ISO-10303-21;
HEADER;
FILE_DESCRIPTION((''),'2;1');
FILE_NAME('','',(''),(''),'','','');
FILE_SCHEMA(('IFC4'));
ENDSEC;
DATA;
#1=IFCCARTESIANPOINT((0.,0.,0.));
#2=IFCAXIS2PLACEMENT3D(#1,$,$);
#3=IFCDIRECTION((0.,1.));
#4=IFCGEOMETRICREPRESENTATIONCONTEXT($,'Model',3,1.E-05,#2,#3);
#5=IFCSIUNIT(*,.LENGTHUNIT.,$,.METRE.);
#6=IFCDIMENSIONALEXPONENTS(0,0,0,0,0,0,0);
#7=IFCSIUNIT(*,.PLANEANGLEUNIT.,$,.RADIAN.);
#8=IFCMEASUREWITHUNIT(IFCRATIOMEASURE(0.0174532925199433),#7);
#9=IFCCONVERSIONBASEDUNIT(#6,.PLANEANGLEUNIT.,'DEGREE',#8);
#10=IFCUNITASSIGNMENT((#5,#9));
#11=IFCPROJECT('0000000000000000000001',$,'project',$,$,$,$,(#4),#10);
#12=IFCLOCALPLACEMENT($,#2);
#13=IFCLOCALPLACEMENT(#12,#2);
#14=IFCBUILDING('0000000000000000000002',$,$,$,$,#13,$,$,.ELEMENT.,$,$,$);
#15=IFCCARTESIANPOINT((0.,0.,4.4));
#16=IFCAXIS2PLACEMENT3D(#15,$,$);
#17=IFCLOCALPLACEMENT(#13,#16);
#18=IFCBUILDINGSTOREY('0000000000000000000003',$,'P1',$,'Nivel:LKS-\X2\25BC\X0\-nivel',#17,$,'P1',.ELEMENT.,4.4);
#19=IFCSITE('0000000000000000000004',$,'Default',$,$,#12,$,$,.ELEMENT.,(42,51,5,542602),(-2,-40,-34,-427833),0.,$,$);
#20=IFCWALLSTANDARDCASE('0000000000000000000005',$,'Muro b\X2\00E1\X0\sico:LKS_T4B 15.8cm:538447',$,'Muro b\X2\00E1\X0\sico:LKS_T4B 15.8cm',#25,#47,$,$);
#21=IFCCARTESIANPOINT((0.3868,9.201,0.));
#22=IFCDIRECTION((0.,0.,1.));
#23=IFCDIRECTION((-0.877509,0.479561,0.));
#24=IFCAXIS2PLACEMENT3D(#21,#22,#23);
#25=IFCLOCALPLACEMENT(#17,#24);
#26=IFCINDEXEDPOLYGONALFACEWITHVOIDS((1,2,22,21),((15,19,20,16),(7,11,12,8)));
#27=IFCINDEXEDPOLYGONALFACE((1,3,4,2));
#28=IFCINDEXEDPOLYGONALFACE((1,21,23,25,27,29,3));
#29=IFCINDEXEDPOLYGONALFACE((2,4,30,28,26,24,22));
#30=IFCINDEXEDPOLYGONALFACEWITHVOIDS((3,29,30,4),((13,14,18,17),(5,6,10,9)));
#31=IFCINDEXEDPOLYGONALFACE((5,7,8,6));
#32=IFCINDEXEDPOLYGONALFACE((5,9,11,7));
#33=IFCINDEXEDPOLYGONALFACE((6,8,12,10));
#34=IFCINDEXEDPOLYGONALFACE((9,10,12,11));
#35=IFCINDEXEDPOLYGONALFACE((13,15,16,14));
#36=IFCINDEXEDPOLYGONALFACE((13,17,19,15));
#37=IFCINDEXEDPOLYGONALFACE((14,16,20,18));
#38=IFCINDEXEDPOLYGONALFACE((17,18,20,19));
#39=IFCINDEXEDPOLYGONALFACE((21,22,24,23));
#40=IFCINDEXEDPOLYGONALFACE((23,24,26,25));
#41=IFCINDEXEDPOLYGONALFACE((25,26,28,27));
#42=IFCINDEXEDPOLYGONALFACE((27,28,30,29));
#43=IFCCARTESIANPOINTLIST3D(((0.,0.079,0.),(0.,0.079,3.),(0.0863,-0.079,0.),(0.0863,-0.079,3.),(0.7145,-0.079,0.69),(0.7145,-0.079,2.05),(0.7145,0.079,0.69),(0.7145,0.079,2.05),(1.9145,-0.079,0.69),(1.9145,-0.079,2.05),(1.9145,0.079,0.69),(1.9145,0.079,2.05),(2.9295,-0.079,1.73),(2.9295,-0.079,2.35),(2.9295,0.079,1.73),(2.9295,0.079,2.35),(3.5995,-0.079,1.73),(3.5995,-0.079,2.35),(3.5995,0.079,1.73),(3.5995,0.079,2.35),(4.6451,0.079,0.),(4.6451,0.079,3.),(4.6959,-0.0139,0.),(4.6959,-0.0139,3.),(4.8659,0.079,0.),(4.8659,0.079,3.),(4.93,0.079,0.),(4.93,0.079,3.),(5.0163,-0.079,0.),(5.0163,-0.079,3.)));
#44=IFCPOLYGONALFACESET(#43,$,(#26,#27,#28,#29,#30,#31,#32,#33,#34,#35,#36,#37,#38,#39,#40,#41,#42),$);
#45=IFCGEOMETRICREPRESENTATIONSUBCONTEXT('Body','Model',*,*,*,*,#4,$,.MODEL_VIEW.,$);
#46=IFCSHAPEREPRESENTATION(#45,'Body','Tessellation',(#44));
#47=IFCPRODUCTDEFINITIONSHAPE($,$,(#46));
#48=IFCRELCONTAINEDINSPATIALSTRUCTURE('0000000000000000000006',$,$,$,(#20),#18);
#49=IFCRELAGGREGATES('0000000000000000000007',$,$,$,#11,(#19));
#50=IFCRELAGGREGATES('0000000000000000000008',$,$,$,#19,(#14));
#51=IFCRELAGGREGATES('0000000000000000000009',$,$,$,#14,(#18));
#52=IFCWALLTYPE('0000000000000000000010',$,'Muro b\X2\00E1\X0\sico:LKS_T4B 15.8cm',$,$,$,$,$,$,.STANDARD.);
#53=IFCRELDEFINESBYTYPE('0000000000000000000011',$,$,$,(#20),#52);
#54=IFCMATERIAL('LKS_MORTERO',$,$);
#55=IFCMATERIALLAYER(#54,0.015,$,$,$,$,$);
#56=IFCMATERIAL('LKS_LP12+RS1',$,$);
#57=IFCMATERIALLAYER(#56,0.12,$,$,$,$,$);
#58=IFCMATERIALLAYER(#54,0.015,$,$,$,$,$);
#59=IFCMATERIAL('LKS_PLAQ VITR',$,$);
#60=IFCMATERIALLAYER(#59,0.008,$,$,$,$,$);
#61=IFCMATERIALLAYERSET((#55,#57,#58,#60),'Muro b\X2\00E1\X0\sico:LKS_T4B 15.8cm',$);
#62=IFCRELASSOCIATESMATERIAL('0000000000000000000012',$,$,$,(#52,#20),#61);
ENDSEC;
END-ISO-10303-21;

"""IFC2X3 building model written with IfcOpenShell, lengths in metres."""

from ifc_helpers import new_model, entity, si_unit, converted_unit, direction, frame, frame_2d, origin, place, context, subcontext, project, spatial, polyline, rectangle, outline, extrude, clip, bounded_halfspace, material, layer, layer_set, layer_usage, type_object, element, save


model = new_model("IFC2X3")

# Units and contexts
model_context = context("Model", 3, precision=1e-05, world=origin(), true_north=direction((0.0, 1.0)))
body_context = subcontext(model_context, "Body", "Model", "MODEL_VIEW")
ifc_project = project(units=[si_unit("LENGTHUNIT", "METRE"), converted_unit("PLANEANGLEUNIT", "DEGREE", entity("IfcRatioMeasure", 0.0174532925199433), si_unit("PLANEANGLEUNIT", "RADIAN"), dimensions=[0, 0, 0, 0, 0, 0, 0])], contexts=[model_context])

# Site, building, storey
site_placement = place(None, origin())
site = spatial("IfcSite", under=ifc_project, at=site_placement, Name="Default", CompositionType="ELEMENT", RefLatitude=(42, 51, 5, 542602), RefLongitude=(-2, -40, -34, -427833), RefElevation=0.0)
building_placement = place(site_placement, origin())
building = spatial("IfcBuilding", under=site, at=building_placement, CompositionType="ELEMENT")
storey_placement = place(building_placement, frame((0.0, 0.0, 4.4)))
storey = spatial("IfcBuildingStorey", under=building, at=storey_placement, Name="P1", ObjectType="Nivel:LKS-▼-nivel", LongName="P1", CompositionType="ELEMENT", Elevation=4.4)

# Wall, openings
ifc_material_1 = material(Name="LKS_MORTERO")
ifc_layer_1 = layer(ifc_material_1, 0.015)
ifc_material_2 = material(Name="LKS_LP12+RS1")
ifc_layer_2 = layer(ifc_material_2, 0.12)
ifc_layer_3 = layer(ifc_material_1, 0.015)
ifc_material_3 = material(Name="LKS_PLAQ VITR")
ifc_layer_4 = layer(ifc_material_3, 0.008)
ifc_layer_set_1 = layer_set([ifc_layer_1, ifc_layer_2, ifc_layer_3, ifc_layer_4], Name="Muro básico:LKS_T4B 15.8cm")
ifc_layer_usage_1 = layer_usage(ifc_layer_set_1, "AXIS2", "POSITIVE", -0.079)
wall_type_1 = type_object("IfcWallType", Name="Muro básico:LKS_T4B 15.8cm", PredefinedType="STANDARD", material=ifc_layer_set_1)
wall_1_placement = place(storey_placement, frame((0.3868, 9.201, 0.0), z_axis=(0.0, 0.0, 1.0), x_axis=(-0.877509, 0.479561, 0.0)))
wall_1 = element("IfcWallStandardCase", 1, at=wall_1_placement, inside=storey, type_object=wall_type_1, material=ifc_layer_usage_1, Name="Muro básico:LKS_T4B 15.8cm:538447", ObjectType="Muro básico:LKS_T4B 15.8cm", context=body_context, shape_type="Clipping", body=[
    clip(clip(extrude(outline(polyline([(5.0163, -0.079), (4.9306, 0.078), (4.93, 0.079), (4.8659, 0.079), (4.6959, -0.0139), (4.6457, 0.078), (4.6451, 0.079), (3.1672, 0.079), (3.0672, 0.079), (0.2712, 0.079), (0.0, 0.079), (0.0006, 0.078), (0.0863, -0.079), (5.0163, -0.079)])), origin(), (0.0, 0.0, 1.0), 3.0), bounded_halfspace(frame((4.6959, -0.0139, 3.0), z_axis=(-0.877509, -0.479561, 0.0), x_axis=(0.0, 0.0, -1.0)), True, frame((4.6959, -0.0139, 3.0), z_axis=(-0.877509, -0.479561, 0.0), x_axis=(0.0, 0.0, -1.0)), polyline([(0.0, 0.0), (0.0, -0.1059), (3.0, -0.1059), (3.0, -0.1047), (3.0, 0.0), (0.33, 0.0), (0.0, 0.0)]))), bounded_halfspace(frame((4.6959, -0.0139, 0.0), z_axis=(0.479561, -0.877509, 0.0), x_axis=(0.0, 0.0, -1.0)), True, frame((4.6959, -0.0139, 0.0), z_axis=(0.479561, -0.877509, 0.0), x_axis=(0.0, 0.0, -1.0)), polyline([(0.0, 0.0), (0.0, 0.1938), (-3.0, 0.1938), (-3.0, 0.0), (-2.67, 0.0), (0.0, 0.0)]))),
])
opening_1_placement = place(wall_1_placement, origin())
element("IfcOpeningElement", 2, at=opening_1_placement, cuts=wall_1, ObjectType="Opening", context=body_context, shape_type="SweptSolid", body=[
    extrude(rectangle(XDim=2.1, YDim=0.1, at=frame_2d((0.0, 0.0), x_axis=(0.0, 1.0))), frame((3.1179, 0.2346, 4.05), z_axis=(0.000526, 1.0, 0.0), x_axis=(1.0, -0.000526, 0.0)), (0.0, 0.0, 1.0), 0.72),
])
opening_2_placement = place(wall_1_placement, frame((3.5995, 0.079, 1.73)))
element("IfcOpeningElement", 3, at=opening_2_placement, cuts=wall_1, ObjectType="Opening", context=body_context, shape_type="SweptSolid", body=[
    extrude(rectangle(XDim=0.62, YDim=0.67, at=frame_2d((0.31, 0.335), x_axis=(1.0, 0.0))), frame((0.0, 0.0, 0.0), z_axis=(0.0, -1.0, 0.0), x_axis=(0.0, 0.0, 1.0)), (0.0, 0.0, 1.0), 0.158),
])
opening_3_placement = place(wall_1_placement, frame((1.9145, 0.079, 0.69)))
element("IfcOpeningElement", 4, at=opening_3_placement, cuts=wall_1, ObjectType="Opening", context=body_context, shape_type="SweptSolid", body=[
    extrude(rectangle(XDim=1.36, YDim=1.2, at=frame_2d((0.68, 0.6), x_axis=(1.0, 0.0))), frame((0.0, 0.0, 0.0), z_axis=(0.0, -1.0, 0.0), x_axis=(0.0, 0.0, 1.0)), (0.0, 0.0, 1.0), 0.158),
])

save(model, "model.ifc")
